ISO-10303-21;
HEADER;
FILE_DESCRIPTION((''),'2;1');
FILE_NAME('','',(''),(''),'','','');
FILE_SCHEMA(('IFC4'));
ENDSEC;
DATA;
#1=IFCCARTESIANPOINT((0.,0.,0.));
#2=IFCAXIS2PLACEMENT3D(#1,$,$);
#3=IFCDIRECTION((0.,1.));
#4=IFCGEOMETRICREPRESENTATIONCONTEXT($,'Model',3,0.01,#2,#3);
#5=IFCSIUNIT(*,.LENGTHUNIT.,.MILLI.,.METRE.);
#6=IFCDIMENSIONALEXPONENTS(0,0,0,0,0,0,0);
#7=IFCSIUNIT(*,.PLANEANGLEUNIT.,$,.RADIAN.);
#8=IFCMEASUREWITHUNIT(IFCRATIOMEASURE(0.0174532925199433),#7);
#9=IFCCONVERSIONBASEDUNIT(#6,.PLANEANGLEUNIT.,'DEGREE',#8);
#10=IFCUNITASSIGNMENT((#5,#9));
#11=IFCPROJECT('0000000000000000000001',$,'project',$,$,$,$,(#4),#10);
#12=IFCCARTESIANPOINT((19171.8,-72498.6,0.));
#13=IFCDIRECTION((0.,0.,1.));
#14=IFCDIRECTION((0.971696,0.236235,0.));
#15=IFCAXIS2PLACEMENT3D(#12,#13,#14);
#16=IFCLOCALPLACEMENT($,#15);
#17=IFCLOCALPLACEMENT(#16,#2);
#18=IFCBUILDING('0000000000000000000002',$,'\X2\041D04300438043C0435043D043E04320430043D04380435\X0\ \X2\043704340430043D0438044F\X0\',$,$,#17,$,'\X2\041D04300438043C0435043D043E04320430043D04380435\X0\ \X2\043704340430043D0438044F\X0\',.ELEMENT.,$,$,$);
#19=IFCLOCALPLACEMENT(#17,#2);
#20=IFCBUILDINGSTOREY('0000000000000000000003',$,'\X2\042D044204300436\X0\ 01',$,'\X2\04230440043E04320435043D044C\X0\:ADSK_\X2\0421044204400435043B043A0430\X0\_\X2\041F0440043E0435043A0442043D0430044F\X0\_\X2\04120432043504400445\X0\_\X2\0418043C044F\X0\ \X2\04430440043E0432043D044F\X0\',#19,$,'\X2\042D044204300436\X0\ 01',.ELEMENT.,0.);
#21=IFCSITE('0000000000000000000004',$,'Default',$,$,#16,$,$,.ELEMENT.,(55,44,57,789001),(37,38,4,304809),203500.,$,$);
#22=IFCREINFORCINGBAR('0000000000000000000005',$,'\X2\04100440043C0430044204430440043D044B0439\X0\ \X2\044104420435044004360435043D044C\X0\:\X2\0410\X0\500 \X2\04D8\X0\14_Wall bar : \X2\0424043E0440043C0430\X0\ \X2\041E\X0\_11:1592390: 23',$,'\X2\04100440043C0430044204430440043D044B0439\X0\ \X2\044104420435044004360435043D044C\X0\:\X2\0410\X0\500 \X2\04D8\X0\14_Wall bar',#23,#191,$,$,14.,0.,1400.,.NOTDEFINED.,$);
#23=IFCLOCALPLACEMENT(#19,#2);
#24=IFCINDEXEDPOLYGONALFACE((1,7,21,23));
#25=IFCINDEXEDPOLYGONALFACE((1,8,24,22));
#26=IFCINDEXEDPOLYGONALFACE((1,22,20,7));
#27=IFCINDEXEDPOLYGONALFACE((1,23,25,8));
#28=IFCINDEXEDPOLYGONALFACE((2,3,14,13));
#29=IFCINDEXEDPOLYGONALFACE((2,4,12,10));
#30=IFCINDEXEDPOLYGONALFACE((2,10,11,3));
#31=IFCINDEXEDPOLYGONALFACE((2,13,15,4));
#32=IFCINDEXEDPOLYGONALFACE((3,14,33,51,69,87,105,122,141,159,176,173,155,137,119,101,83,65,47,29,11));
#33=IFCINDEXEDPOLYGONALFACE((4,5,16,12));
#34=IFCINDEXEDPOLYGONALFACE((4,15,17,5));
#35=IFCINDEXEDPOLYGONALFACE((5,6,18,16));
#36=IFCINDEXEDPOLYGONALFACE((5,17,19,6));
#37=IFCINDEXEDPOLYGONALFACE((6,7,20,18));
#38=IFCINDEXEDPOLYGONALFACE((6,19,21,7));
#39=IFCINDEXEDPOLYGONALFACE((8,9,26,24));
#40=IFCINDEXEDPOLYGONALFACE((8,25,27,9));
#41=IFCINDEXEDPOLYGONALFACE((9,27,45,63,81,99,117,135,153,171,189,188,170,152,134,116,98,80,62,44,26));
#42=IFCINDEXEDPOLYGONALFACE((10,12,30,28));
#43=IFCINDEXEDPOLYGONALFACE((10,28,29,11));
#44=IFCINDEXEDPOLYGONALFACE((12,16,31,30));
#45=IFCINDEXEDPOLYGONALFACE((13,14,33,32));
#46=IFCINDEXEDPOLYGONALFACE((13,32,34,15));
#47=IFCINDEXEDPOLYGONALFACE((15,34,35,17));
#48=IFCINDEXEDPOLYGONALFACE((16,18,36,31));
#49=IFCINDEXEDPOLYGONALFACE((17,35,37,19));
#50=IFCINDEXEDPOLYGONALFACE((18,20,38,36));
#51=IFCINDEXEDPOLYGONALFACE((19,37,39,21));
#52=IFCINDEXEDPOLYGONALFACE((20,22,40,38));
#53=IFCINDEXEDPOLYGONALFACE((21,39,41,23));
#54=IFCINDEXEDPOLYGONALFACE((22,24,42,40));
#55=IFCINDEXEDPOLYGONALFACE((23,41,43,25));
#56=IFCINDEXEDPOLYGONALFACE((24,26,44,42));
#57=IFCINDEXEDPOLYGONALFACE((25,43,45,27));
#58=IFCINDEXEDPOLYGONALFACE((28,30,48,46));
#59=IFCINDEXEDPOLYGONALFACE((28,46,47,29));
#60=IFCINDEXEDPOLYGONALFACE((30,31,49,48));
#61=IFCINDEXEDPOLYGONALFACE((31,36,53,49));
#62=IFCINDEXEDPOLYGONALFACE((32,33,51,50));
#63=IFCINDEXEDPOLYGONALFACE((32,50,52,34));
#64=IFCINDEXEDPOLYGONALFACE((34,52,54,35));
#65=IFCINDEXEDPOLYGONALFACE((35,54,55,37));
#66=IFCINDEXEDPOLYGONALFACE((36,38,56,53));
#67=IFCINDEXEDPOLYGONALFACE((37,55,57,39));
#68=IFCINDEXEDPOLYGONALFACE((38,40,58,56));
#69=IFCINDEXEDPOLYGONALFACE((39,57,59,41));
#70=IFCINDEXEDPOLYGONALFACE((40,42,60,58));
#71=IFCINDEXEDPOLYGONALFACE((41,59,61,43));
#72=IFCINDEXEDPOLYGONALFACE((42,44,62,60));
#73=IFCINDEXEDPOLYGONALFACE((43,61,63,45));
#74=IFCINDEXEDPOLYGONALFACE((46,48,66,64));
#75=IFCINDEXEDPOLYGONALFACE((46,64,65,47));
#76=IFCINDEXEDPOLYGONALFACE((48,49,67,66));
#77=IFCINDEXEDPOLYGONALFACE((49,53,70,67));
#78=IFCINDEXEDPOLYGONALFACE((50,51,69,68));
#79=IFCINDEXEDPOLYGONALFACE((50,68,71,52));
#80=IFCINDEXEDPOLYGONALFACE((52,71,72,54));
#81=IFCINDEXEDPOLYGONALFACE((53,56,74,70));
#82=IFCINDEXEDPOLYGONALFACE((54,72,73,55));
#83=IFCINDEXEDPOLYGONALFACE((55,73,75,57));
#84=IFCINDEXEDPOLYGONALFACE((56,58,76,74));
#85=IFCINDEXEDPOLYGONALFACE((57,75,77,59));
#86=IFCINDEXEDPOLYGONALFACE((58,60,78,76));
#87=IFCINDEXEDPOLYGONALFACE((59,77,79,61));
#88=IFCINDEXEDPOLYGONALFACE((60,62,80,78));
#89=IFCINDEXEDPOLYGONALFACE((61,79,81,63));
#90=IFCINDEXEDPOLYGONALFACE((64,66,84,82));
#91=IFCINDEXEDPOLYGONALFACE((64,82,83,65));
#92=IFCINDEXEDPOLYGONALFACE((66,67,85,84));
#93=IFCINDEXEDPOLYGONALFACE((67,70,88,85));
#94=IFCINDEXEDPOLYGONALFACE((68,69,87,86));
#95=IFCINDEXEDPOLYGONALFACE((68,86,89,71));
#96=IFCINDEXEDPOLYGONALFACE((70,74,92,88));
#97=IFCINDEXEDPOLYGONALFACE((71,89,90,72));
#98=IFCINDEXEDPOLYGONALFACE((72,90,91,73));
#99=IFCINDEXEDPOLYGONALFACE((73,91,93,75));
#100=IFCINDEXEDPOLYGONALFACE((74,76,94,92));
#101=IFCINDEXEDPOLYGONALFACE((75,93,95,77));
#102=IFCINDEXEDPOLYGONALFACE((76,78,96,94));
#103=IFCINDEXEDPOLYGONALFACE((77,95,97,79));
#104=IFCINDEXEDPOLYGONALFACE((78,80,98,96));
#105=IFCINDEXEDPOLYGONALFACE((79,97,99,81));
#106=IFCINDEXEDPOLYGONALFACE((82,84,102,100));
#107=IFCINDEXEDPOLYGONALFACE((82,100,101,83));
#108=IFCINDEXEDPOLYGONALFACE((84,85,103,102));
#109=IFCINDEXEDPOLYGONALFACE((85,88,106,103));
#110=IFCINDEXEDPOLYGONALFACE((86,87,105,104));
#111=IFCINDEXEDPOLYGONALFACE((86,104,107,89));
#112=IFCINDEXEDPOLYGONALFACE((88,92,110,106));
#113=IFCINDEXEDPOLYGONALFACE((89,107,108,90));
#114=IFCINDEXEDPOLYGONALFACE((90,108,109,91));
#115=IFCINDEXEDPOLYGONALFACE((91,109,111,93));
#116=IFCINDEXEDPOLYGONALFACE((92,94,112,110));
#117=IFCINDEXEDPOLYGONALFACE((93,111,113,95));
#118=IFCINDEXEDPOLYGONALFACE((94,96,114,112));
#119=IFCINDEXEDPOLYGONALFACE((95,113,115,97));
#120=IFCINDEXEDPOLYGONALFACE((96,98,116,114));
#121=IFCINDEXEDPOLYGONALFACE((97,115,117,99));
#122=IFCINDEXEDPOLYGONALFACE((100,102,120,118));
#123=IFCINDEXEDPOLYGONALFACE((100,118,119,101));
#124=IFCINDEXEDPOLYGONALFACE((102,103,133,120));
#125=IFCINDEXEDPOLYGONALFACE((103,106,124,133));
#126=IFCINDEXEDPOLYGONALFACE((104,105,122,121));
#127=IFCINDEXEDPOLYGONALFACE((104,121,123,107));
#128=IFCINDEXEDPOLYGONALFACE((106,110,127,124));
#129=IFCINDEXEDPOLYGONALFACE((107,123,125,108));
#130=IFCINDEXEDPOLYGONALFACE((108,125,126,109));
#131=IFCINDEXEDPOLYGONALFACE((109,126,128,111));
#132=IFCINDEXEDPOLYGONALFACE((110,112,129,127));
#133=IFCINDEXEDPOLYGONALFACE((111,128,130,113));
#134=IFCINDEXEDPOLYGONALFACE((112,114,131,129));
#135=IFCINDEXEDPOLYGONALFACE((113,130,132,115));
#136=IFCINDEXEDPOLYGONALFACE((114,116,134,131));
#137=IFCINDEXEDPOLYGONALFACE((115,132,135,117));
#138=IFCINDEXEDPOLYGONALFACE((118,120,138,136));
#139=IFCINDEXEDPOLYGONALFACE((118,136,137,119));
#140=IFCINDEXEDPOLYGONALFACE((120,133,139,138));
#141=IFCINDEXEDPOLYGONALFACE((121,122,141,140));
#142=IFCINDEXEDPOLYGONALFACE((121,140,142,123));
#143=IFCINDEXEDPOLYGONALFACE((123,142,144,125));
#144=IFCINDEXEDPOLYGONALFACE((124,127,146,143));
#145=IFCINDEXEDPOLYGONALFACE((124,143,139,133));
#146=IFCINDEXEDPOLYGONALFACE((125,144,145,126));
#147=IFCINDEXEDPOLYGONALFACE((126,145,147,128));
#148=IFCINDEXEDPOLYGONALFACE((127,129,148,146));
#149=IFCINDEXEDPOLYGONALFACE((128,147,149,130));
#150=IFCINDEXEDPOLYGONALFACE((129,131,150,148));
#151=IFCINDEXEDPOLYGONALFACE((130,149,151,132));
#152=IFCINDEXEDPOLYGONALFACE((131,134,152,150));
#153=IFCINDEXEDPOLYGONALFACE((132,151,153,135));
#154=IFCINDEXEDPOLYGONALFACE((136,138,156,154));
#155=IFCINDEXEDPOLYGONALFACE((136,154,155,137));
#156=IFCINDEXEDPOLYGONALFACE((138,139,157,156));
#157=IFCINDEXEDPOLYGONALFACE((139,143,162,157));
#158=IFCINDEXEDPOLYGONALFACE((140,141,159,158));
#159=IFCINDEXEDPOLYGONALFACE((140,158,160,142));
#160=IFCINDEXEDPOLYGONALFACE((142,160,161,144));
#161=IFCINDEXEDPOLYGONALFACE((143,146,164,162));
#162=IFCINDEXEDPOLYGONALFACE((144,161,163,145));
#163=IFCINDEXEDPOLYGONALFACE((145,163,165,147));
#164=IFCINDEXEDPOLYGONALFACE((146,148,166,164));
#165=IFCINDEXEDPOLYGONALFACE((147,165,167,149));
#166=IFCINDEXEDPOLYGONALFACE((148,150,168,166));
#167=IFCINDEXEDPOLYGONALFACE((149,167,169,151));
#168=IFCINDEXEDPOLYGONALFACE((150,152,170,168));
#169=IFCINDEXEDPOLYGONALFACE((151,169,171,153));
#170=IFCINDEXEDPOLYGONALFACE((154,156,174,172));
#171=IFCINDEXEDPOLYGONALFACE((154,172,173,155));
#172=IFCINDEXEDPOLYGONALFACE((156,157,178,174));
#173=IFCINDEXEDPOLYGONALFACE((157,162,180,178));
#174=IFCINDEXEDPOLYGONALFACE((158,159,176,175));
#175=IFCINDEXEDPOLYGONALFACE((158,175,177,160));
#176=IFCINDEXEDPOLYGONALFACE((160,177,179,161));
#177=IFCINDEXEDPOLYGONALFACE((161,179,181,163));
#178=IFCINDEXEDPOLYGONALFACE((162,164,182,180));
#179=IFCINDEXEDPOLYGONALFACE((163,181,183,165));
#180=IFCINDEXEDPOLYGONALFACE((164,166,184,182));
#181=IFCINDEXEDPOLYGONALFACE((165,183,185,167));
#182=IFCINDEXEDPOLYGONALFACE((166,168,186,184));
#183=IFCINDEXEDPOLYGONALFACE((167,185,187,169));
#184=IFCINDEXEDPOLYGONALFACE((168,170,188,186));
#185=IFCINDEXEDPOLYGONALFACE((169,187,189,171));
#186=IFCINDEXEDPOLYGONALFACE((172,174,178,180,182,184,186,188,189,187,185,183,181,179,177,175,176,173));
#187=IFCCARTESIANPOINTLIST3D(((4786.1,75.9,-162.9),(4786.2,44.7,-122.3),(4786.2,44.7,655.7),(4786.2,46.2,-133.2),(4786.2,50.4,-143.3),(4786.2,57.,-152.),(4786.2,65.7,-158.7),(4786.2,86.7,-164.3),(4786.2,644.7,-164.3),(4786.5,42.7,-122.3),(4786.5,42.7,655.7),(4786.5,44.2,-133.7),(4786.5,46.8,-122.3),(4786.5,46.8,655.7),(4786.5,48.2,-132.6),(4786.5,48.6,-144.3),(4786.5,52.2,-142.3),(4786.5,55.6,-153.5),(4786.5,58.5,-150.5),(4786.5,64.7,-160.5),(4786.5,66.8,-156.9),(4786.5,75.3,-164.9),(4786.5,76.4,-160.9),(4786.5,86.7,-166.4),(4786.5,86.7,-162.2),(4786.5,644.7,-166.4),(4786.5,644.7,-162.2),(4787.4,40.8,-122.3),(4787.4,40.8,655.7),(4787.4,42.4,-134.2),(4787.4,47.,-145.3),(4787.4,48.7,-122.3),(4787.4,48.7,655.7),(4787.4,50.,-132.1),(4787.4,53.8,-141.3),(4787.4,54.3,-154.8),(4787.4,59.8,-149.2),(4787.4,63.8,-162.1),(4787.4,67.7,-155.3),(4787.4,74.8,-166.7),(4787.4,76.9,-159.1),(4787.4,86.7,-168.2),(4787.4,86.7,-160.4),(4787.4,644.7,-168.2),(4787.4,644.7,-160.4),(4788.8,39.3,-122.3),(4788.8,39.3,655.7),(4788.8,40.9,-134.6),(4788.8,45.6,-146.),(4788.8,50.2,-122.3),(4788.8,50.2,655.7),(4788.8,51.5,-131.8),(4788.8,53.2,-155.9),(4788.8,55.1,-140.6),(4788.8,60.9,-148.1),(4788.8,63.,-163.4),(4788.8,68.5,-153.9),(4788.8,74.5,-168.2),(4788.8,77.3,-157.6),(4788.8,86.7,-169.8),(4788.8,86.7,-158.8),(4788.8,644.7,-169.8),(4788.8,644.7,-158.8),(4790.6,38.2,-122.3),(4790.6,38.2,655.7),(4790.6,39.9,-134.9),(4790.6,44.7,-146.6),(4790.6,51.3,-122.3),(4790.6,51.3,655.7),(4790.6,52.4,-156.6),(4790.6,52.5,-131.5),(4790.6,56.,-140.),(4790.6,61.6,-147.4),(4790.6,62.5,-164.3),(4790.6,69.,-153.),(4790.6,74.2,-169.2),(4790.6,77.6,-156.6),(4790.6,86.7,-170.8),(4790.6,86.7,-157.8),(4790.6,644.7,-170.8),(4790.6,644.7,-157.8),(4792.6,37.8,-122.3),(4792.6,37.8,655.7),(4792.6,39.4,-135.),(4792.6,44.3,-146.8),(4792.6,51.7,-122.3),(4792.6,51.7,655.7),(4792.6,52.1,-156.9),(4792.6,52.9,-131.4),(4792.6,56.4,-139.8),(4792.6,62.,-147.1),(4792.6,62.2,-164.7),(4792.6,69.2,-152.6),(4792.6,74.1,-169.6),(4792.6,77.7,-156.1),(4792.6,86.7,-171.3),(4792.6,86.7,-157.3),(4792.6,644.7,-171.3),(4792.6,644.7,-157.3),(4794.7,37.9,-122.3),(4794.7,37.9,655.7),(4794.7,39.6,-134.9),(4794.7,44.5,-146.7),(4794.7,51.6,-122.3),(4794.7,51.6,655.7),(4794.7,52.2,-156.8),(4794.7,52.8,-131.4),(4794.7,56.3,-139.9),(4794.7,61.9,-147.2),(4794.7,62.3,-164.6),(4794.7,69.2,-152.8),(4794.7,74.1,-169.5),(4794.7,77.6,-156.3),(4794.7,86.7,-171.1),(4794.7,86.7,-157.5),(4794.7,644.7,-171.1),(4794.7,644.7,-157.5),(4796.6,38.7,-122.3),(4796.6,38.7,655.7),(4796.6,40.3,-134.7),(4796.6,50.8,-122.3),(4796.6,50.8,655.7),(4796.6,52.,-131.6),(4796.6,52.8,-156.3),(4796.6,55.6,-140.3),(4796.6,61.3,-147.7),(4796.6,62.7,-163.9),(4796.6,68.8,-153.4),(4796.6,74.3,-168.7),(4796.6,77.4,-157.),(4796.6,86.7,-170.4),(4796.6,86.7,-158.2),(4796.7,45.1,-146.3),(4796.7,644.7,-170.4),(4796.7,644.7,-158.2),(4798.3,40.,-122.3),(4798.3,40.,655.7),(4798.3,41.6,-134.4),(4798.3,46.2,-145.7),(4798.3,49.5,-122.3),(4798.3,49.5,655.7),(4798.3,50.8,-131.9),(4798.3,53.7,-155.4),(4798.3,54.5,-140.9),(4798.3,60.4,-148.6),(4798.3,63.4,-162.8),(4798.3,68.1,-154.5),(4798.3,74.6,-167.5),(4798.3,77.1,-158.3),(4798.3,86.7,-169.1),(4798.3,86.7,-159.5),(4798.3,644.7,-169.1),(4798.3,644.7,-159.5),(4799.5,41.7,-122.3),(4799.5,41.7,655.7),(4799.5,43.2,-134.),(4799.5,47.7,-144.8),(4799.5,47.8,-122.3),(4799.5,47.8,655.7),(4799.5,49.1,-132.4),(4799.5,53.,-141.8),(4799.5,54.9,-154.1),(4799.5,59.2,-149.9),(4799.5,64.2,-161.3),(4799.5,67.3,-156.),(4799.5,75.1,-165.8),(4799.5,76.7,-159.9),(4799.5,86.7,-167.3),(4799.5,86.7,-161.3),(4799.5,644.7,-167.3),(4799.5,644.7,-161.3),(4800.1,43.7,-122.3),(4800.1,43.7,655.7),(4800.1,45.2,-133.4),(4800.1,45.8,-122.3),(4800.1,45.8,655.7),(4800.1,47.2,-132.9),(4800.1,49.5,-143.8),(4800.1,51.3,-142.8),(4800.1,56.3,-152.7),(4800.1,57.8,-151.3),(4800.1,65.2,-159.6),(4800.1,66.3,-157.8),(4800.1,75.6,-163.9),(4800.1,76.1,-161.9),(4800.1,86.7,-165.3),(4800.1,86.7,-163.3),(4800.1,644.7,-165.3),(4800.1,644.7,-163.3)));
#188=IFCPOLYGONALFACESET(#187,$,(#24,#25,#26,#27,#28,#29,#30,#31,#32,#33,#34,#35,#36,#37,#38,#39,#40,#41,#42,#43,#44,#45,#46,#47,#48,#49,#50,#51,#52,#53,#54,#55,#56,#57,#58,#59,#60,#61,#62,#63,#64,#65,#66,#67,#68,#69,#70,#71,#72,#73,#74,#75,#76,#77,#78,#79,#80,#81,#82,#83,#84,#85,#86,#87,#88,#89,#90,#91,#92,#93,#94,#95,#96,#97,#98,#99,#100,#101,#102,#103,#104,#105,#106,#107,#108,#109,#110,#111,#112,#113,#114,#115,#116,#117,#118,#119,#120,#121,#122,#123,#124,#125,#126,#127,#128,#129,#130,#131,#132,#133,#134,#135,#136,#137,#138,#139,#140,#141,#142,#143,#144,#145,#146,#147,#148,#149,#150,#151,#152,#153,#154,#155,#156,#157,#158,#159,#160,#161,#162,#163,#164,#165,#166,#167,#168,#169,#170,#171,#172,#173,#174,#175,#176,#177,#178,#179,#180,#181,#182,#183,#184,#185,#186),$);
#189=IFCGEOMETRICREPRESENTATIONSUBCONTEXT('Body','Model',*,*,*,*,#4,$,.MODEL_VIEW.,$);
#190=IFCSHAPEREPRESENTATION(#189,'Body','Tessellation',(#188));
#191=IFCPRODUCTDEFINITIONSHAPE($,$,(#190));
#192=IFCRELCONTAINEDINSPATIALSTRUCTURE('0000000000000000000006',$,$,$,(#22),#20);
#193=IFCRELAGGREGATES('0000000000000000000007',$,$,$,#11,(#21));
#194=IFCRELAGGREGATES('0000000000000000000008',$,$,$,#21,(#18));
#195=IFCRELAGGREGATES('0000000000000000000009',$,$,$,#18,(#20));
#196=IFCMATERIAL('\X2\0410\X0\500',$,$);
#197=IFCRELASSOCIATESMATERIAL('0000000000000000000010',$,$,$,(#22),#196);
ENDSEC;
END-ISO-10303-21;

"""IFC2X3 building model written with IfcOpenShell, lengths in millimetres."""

from ifc_helpers import new_model, entity, si_unit, converted_unit, direction, frame, origin, place, context, subcontext, project, spatial, material, element, save


model = new_model("IFC2X3")

# Units and contexts
model_context = context("Model", 3, precision=0.01, world=origin(), true_north=direction((0.0, 1.0)))
body_context = subcontext(model_context, "Body", "Model", "MODEL_VIEW")
ifc_project = project(units=[si_unit("LENGTHUNIT", "METRE", prefix="MILLI"), converted_unit("PLANEANGLEUNIT", "DEGREE", entity("IfcRatioMeasure", 0.0174532925199433), si_unit("PLANEANGLEUNIT", "RADIAN"), dimensions=[0, 0, 0, 0, 0, 0, 0])], contexts=[model_context])

# Site, building, storey
site_placement = place(None, frame((19171.8, -72498.6, 0.0), z_axis=(0.0, 0.0, 1.0), x_axis=(0.971696, 0.236235, 0.0)))
site = spatial("IfcSite", under=ifc_project, at=site_placement, Name="Default", CompositionType="ELEMENT", RefLatitude=(55, 44, 57, 789001), RefLongitude=(37, 38, 4, 304809), RefElevation=203500.0)
building_placement = place(site_placement, origin())
building = spatial("IfcBuilding", under=site, at=building_placement, Name="Наименование здания", LongName="Наименование здания", CompositionType="ELEMENT")
storey_placement = place(building_placement, origin())
storey = spatial("IfcBuildingStorey", under=building, at=storey_placement, Name="Этаж 01", ObjectType="Уровень:ADSK_Стрелка_Проектная_Вверх_Имя уровня", LongName="Этаж 01", CompositionType="ELEMENT", Elevation=0.0)

# Reinforcing bar
ifc_material = material(Name="А500")
placement = place(storey_placement, origin())
element("IfcReinforcingBar", 1, at=placement, inside=storey, material=ifc_material, Name="Арматурный стержень:А500 Ә14_Wall bar : Форма О_11:1592390: 23", ObjectType="Арматурный стержень:А500 Ә14_Wall bar", BarLength=1400.0, BarRole="NOTDEFINED", CrossSectionArea=0.0, NominalDiameter=14.0, context=body_context, shape_type="AdvancedSweptSolid", body=[
    entity("IfcSweptDiskSolid", entity("IfcCompositeCurve", [entity("IfcCompositeCurveSegment", "CONTINUOUS", True, entity("IfcPolyline", [entity("IfcCartesianPoint", [4793.1, 44.7, 655.7]), entity("IfcCartesianPoint", [4793.1, 44.7, -122.3])])), entity("IfcCompositeCurveSegment", "CONTINUOUS", True, entity("IfcTrimmedCurve", entity("IfcCircle", entity("IfcAxis2Placement3D", entity("IfcCartesianPoint", [4793.1, 86.7, -122.3]), entity("IfcDirection", [1.0, 0.0, 0.0]), entity("IfcDirection", [0.0, 0.0, -1.0])), 42.0), [entity("IfcParameterValue", 270.0)], [entity("IfcParameterValue", 360.0)], True, "PARAMETER")), entity("IfcCompositeCurveSegment", "CONTINUOUS", True, entity("IfcPolyline", [entity("IfcCartesianPoint", [4793.1, 86.7, -164.3]), entity("IfcCartesianPoint", [4793.1, 644.7, -164.3])]))], False), 7.0, None, 0.0, 92.0),
])

save(model, "model.ifc")
